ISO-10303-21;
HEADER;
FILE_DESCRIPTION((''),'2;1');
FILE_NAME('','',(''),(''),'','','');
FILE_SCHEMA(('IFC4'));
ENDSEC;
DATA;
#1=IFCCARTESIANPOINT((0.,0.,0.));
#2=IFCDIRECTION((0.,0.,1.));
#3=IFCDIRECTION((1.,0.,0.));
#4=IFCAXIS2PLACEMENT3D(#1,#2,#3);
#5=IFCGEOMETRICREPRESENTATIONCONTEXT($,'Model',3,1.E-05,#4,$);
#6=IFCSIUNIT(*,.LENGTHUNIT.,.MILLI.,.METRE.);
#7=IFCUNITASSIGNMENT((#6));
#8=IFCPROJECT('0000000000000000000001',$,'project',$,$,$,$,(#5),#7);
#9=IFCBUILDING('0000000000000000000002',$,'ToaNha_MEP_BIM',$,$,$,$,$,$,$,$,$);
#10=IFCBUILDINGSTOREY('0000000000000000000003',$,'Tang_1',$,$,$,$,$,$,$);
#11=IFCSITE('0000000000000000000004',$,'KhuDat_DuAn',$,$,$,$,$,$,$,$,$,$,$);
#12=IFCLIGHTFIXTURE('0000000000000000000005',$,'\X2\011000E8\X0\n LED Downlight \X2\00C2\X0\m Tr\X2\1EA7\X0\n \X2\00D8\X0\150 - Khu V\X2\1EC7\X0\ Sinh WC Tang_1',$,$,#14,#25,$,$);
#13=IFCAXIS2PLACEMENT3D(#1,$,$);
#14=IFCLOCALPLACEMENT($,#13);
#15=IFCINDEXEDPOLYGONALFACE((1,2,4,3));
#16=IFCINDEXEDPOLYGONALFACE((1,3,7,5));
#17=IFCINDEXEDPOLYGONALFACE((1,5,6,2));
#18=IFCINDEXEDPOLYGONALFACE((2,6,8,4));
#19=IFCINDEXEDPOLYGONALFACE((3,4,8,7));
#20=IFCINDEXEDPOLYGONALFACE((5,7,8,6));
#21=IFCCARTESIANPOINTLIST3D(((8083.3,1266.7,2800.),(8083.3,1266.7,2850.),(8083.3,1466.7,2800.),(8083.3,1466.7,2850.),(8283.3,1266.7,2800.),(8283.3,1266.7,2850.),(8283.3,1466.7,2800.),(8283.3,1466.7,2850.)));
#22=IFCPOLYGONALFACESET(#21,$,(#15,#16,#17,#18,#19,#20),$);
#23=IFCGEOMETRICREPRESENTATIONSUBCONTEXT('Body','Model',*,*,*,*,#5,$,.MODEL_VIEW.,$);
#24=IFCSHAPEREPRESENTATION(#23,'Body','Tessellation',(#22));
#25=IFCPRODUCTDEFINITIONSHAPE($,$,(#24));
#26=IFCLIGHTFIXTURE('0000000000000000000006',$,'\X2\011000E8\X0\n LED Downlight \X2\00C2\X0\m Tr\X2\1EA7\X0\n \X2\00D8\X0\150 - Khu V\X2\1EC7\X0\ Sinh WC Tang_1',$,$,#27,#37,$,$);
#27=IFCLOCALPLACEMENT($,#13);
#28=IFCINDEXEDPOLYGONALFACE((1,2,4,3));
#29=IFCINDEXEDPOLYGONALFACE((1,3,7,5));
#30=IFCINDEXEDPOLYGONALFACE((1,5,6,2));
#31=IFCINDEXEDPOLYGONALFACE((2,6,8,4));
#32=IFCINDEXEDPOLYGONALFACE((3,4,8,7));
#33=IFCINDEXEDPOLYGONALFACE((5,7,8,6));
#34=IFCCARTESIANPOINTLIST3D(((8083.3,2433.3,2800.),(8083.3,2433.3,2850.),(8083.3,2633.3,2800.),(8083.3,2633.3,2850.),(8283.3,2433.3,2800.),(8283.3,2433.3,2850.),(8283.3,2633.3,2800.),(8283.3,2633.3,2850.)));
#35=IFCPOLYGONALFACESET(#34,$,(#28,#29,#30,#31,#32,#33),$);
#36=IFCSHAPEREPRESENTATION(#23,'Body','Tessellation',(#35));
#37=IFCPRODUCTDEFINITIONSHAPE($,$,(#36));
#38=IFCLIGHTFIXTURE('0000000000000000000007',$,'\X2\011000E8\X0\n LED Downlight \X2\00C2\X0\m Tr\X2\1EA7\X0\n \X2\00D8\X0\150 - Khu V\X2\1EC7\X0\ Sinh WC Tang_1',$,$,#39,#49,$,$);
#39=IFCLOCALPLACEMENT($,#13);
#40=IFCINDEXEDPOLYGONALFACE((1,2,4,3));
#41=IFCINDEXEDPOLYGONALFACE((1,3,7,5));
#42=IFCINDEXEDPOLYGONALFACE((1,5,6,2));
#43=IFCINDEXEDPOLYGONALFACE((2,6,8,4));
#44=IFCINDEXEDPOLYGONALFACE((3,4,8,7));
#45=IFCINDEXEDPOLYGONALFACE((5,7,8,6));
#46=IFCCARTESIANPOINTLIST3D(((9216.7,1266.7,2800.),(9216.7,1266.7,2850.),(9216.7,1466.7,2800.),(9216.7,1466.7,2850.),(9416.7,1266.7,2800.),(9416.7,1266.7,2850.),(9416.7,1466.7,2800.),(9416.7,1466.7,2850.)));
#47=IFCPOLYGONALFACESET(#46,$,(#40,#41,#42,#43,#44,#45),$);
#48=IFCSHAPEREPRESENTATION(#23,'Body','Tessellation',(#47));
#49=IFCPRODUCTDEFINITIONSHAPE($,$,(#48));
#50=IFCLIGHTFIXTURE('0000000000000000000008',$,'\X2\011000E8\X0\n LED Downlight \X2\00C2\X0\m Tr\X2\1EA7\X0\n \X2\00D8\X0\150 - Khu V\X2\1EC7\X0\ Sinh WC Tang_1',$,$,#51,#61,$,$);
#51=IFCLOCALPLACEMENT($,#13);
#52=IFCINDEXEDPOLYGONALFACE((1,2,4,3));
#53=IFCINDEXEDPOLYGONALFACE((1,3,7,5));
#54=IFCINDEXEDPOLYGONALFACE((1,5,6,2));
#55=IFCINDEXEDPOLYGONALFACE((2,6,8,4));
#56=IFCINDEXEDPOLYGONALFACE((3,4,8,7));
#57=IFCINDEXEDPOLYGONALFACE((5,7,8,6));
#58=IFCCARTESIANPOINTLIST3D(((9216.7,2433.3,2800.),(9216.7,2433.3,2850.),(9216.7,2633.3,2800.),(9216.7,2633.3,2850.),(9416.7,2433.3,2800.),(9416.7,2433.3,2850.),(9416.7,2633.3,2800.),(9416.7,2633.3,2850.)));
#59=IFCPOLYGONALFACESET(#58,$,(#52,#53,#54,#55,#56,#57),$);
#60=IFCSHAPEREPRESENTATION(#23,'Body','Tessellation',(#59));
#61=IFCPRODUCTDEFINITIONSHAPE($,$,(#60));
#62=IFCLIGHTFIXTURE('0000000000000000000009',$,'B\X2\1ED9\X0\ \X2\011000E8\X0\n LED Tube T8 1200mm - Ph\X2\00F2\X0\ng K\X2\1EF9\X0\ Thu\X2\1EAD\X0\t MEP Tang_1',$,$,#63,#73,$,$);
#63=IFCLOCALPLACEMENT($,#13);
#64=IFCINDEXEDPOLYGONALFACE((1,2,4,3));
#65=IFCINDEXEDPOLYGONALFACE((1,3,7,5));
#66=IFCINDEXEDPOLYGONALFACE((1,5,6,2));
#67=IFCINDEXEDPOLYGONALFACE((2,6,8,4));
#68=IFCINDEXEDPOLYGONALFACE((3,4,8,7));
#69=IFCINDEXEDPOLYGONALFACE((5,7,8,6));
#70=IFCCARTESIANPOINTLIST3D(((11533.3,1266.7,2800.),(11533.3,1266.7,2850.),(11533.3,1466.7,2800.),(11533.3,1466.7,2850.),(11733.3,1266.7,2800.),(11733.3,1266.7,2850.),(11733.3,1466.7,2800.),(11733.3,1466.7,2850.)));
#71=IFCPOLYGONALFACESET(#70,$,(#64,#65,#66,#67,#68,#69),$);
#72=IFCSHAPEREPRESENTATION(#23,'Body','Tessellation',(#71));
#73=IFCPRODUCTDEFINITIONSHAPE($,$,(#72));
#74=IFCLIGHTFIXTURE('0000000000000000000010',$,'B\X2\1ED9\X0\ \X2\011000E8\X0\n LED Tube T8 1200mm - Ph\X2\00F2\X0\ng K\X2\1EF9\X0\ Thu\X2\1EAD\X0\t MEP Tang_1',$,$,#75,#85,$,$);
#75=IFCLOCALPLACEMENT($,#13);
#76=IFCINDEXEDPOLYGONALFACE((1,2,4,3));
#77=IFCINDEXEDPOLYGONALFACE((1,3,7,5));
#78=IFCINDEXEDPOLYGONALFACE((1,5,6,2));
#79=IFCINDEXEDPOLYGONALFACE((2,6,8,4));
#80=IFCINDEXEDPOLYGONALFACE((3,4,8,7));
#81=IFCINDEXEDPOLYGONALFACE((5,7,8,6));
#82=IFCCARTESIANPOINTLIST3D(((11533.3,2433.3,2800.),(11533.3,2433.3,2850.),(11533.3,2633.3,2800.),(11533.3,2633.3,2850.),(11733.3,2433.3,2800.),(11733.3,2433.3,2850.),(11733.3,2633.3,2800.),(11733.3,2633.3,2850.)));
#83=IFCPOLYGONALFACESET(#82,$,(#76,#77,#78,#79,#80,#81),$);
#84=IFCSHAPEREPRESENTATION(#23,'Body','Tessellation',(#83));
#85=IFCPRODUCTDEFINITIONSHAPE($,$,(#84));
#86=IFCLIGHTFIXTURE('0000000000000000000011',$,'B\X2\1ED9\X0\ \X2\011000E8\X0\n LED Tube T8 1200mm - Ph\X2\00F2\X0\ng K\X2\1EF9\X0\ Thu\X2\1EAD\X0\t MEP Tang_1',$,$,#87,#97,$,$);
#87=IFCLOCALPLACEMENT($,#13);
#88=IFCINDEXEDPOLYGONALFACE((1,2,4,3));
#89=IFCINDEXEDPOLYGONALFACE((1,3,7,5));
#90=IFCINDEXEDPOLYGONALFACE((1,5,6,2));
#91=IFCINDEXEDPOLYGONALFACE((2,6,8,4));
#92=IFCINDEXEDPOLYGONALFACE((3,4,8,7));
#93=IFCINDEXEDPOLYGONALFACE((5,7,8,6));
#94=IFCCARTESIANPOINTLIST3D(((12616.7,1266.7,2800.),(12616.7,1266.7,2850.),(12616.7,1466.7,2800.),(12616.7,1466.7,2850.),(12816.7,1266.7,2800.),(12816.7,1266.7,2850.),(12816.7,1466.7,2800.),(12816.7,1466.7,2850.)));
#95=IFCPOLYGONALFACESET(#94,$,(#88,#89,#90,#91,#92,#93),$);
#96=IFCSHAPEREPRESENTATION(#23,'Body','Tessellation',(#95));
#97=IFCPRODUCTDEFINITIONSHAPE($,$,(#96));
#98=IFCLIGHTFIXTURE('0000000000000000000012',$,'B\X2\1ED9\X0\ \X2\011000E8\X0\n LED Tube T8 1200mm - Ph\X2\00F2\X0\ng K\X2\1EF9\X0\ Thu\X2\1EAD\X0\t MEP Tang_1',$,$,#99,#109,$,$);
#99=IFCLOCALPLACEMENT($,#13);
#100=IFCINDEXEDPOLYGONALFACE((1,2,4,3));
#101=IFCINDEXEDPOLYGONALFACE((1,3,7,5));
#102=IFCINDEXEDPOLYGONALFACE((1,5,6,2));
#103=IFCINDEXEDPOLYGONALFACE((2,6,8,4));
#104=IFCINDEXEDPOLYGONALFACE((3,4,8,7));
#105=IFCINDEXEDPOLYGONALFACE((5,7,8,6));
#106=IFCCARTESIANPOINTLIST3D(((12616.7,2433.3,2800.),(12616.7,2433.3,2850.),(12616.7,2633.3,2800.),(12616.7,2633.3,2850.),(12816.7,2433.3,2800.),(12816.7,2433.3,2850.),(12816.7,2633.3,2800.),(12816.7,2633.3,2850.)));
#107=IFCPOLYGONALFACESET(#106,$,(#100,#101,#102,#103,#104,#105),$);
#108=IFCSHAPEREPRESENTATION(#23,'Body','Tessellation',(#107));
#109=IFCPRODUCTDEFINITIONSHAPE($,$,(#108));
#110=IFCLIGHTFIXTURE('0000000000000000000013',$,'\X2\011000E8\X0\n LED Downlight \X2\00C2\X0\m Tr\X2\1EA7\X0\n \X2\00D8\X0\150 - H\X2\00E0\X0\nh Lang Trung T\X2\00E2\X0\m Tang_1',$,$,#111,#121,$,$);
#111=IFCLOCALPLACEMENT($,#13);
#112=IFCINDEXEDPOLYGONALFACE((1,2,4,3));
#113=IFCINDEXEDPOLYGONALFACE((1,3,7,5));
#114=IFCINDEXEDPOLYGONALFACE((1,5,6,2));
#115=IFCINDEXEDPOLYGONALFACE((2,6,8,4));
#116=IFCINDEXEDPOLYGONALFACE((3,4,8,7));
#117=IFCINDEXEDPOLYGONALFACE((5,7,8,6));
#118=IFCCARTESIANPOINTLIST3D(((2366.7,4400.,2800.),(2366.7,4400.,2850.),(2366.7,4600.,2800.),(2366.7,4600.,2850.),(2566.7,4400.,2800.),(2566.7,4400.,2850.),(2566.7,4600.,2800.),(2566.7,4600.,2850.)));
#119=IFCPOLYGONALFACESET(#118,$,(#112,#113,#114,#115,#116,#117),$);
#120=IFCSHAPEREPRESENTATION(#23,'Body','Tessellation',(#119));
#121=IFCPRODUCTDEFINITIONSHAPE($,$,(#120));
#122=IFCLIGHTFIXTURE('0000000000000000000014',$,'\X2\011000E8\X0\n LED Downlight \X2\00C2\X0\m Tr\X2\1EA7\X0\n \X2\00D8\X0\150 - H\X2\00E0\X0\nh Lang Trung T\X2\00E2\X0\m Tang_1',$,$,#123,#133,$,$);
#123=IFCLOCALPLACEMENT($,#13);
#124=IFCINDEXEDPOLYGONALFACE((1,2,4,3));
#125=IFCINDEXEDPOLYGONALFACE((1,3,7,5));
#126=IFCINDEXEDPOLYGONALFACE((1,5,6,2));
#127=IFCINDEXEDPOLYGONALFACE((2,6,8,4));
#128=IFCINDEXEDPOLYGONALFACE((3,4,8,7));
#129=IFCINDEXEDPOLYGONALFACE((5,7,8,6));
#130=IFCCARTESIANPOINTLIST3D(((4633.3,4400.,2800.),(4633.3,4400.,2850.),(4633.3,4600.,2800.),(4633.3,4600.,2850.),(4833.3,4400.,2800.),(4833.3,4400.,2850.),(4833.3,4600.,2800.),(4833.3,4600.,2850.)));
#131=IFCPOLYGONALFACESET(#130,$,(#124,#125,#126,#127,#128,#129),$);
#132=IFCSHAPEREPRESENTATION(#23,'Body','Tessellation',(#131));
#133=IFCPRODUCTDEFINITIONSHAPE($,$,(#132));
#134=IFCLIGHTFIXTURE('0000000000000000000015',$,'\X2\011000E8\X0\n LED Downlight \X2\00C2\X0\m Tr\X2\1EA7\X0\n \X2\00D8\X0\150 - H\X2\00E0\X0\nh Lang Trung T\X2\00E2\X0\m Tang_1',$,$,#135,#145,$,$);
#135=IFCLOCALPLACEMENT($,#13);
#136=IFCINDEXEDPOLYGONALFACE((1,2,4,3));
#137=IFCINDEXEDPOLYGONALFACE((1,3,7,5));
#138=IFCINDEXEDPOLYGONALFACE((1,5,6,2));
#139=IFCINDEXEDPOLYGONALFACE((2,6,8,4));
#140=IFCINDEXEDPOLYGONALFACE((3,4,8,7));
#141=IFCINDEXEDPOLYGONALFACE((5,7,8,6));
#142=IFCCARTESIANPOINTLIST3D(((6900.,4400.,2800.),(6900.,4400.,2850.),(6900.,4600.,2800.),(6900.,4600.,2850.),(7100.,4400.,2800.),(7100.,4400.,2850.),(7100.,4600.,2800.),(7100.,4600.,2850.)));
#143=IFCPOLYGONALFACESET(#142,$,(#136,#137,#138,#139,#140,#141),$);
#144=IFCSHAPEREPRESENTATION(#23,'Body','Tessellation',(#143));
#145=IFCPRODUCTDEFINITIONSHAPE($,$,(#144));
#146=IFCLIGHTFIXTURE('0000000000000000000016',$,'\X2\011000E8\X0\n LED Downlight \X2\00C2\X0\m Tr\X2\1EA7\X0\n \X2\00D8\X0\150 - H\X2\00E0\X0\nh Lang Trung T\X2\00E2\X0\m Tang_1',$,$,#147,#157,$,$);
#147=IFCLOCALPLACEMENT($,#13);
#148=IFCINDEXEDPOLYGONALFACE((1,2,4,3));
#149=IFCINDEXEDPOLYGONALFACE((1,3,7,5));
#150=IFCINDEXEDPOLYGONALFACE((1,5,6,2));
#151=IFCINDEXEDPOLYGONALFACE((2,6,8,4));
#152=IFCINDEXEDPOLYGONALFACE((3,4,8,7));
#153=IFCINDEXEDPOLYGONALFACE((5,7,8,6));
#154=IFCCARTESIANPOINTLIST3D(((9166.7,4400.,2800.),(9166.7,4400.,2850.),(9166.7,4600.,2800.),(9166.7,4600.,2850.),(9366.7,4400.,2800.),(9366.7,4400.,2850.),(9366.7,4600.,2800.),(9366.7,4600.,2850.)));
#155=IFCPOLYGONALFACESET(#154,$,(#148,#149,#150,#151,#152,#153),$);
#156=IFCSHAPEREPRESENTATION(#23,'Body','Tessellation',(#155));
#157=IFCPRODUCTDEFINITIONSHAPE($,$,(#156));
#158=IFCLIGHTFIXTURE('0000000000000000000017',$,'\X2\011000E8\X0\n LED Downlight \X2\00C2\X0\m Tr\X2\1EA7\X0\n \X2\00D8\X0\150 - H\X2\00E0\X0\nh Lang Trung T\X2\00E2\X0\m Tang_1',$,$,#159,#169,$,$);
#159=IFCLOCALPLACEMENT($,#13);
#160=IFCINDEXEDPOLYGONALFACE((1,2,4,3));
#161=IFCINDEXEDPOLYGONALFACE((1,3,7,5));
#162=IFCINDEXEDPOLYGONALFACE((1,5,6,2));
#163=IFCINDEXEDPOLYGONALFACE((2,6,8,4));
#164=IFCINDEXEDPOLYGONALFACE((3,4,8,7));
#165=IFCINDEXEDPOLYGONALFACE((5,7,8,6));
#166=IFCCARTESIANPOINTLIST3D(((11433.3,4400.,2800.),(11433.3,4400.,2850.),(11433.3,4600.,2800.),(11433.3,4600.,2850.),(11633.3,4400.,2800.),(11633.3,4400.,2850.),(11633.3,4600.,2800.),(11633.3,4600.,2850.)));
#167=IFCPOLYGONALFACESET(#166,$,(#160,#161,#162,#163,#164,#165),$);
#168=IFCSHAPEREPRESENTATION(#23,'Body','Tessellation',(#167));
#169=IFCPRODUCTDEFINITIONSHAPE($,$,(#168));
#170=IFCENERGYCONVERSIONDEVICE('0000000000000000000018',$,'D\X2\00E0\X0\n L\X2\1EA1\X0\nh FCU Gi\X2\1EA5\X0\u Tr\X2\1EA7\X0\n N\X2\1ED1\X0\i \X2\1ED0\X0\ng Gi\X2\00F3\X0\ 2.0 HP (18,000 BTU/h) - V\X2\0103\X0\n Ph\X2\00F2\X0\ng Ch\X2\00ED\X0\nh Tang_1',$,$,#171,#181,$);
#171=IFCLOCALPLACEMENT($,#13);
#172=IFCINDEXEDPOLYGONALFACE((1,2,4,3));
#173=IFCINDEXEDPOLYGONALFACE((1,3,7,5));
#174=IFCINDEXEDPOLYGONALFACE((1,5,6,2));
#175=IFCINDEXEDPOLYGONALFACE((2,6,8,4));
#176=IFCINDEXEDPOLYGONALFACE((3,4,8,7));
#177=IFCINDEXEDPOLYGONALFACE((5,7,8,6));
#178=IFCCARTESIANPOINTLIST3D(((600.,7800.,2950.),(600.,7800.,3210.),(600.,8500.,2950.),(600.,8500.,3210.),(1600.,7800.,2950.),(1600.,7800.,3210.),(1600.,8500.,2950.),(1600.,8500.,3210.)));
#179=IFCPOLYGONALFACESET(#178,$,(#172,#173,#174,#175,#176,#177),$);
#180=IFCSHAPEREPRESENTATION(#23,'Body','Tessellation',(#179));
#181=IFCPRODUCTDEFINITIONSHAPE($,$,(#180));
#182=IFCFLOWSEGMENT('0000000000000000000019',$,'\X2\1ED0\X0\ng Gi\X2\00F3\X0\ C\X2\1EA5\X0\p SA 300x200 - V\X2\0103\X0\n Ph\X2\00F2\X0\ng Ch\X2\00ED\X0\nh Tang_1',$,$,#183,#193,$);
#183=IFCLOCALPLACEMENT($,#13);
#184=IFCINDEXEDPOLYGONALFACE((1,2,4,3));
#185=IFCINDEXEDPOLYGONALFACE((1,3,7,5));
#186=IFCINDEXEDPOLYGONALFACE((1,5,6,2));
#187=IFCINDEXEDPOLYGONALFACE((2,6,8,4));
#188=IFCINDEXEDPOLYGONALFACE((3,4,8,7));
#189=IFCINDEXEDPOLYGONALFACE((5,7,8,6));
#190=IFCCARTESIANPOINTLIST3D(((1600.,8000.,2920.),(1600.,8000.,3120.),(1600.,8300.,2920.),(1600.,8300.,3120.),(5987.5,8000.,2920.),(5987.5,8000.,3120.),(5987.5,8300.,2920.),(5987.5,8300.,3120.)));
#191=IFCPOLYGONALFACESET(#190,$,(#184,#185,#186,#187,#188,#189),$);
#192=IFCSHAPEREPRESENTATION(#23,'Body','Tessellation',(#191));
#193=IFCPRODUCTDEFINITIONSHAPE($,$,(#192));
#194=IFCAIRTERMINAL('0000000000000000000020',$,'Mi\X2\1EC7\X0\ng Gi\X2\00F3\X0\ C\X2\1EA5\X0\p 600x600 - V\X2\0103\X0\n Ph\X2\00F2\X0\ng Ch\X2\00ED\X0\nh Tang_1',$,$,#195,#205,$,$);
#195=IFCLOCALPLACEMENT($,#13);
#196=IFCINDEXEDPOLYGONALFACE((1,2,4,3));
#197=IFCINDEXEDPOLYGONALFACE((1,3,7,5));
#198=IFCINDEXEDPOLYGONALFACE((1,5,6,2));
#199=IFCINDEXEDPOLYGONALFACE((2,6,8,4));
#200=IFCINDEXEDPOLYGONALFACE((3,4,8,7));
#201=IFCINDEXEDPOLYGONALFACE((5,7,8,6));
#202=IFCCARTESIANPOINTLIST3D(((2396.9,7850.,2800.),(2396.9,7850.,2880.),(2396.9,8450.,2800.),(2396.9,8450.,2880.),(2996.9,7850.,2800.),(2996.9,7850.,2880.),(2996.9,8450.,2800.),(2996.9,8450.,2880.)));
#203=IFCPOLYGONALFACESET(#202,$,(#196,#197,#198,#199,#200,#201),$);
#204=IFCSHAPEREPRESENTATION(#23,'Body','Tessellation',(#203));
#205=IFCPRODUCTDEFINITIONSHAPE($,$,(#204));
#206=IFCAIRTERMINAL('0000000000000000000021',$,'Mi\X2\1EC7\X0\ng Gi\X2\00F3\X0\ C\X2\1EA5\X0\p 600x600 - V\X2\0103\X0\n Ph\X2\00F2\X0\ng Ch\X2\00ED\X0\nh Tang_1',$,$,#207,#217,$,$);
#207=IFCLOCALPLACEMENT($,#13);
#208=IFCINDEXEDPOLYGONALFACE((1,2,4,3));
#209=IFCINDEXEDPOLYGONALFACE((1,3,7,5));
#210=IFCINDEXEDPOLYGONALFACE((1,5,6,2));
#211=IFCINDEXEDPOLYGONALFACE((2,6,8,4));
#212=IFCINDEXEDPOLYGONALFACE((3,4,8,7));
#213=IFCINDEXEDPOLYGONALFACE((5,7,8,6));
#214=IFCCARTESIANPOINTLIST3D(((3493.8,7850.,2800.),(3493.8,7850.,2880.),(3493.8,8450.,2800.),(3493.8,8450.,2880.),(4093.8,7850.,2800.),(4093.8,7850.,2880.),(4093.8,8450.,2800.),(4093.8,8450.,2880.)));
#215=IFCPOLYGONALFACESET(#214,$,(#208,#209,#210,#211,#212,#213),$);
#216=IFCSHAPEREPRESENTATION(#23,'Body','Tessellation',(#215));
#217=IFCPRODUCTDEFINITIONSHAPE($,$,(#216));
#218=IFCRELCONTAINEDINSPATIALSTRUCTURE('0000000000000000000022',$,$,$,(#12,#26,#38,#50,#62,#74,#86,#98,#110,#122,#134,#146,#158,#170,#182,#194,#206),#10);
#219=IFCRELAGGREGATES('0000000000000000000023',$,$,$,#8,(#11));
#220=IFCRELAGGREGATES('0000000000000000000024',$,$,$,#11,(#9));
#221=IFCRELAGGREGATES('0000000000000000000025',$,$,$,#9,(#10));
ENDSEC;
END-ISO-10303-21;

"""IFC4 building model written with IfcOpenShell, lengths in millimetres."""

from ifc_helpers import new_model, si_unit, frame, origin_with_axes, context, subcontext, project, spatial, polyline, outline, extrude, element, save


model = new_model("IFC4")

# Units and contexts
model_context = context("Model", 3, precision=1e-05, world=origin_with_axes())
body_context = subcontext(model_context, "Body", "Model", "MODEL_VIEW")
ifc_project = project(units=[si_unit("LENGTHUNIT", "METRE", prefix="MILLI")], contexts=[model_context])

# Site, building, storey
site = spatial("IfcSite", under=ifc_project, Name="KhuDat_DuAn")
building = spatial("IfcBuilding", under=site, Name="ToaNha_MEP_BIM")
storey = spatial("IfcBuildingStorey", under=building, Name="Tang_1")

# Light fixtures
element("IfcLightFixture", 1, inside=storey, Name="Đèn LED Downlight Âm Trần Ø150 - Khu Vệ Sinh WC Tang_1", context=body_context, shape_type="SweptSolid", body=[
    extrude(outline(polyline([(8083.3, 1266.7), (8283.3, 1266.7), (8283.3, 1466.7), (8083.3, 1466.7), (8083.3, 1266.7)])), frame((0.0, 0.0, 2800.0), z_axis=(0.0, 0.0, 1.0), x_axis=(1.0, 0.0, 0.0)), (0.0, 0.0, 1.0), 50.0),
])
element("IfcLightFixture", 2, inside=storey, Name="Đèn LED Downlight Âm Trần Ø150 - Khu Vệ Sinh WC Tang_1", context=body_context, shape_type="SweptSolid", body=[
    extrude(outline(polyline([(8083.3, 2433.3), (8283.3, 2433.3), (8283.3, 2633.3), (8083.3, 2633.3), (8083.3, 2433.3)])), frame((0.0, 0.0, 2800.0), z_axis=(0.0, 0.0, 1.0), x_axis=(1.0, 0.0, 0.0)), (0.0, 0.0, 1.0), 50.0),
])
element("IfcLightFixture", 3, inside=storey, Name="Đèn LED Downlight Âm Trần Ø150 - Khu Vệ Sinh WC Tang_1", context=body_context, shape_type="SweptSolid", body=[
    extrude(outline(polyline([(9216.7, 1266.7), (9416.7, 1266.7), (9416.7, 1466.7), (9216.7, 1466.7), (9216.7, 1266.7)])), frame((0.0, 0.0, 2800.0), z_axis=(0.0, 0.0, 1.0), x_axis=(1.0, 0.0, 0.0)), (0.0, 0.0, 1.0), 50.0),
])
element("IfcLightFixture", 4, inside=storey, Name="Đèn LED Downlight Âm Trần Ø150 - Khu Vệ Sinh WC Tang_1", context=body_context, shape_type="SweptSolid", body=[
    extrude(outline(polyline([(9216.7, 2433.3), (9416.7, 2433.3), (9416.7, 2633.3), (9216.7, 2633.3), (9216.7, 2433.3)])), frame((0.0, 0.0, 2800.0), z_axis=(0.0, 0.0, 1.0), x_axis=(1.0, 0.0, 0.0)), (0.0, 0.0, 1.0), 50.0),
])
element("IfcLightFixture", 5, inside=storey, Name="Bộ Đèn LED Tube T8 1200mm - Phòng Kỹ Thuật MEP Tang_1", context=body_context, shape_type="SweptSolid", body=[
    extrude(outline(polyline([(11533.3, 1266.7), (11733.3, 1266.7), (11733.3, 1466.7), (11533.3, 1466.7), (11533.3, 1266.7)])), frame((0.0, 0.0, 2800.0), z_axis=(0.0, 0.0, 1.0), x_axis=(1.0, 0.0, 0.0)), (0.0, 0.0, 1.0), 50.0),
])
element("IfcLightFixture", 6, inside=storey, Name="Bộ Đèn LED Tube T8 1200mm - Phòng Kỹ Thuật MEP Tang_1", context=body_context, shape_type="SweptSolid", body=[
    extrude(outline(polyline([(11533.3, 2433.3), (11733.3, 2433.3), (11733.3, 2633.3), (11533.3, 2633.3), (11533.3, 2433.3)])), frame((0.0, 0.0, 2800.0), z_axis=(0.0, 0.0, 1.0), x_axis=(1.0, 0.0, 0.0)), (0.0, 0.0, 1.0), 50.0),
])
element("IfcLightFixture", 7, inside=storey, Name="Bộ Đèn LED Tube T8 1200mm - Phòng Kỹ Thuật MEP Tang_1", context=body_context, shape_type="SweptSolid", body=[
    extrude(outline(polyline([(12616.7, 1266.7), (12816.7, 1266.7), (12816.7, 1466.7), (12616.7, 1466.7), (12616.7, 1266.7)])), frame((0.0, 0.0, 2800.0), z_axis=(0.0, 0.0, 1.0), x_axis=(1.0, 0.0, 0.0)), (0.0, 0.0, 1.0), 50.0),
])
element("IfcLightFixture", 8, inside=storey, Name="Bộ Đèn LED Tube T8 1200mm - Phòng Kỹ Thuật MEP Tang_1", context=body_context, shape_type="SweptSolid", body=[
    extrude(outline(polyline([(12616.7, 2433.3), (12816.7, 2433.3), (12816.7, 2633.3), (12616.7, 2633.3), (12616.7, 2433.3)])), frame((0.0, 0.0, 2800.0), z_axis=(0.0, 0.0, 1.0), x_axis=(1.0, 0.0, 0.0)), (0.0, 0.0, 1.0), 50.0),
])
element("IfcLightFixture", 9, inside=storey, Name="Đèn LED Downlight Âm Trần Ø150 - Hành Lang Trung Tâm Tang_1", context=body_context, shape_type="SweptSolid", body=[
    extrude(outline(polyline([(2366.7, 4400.0), (2566.7, 4400.0), (2566.7, 4600.0), (2366.7, 4600.0), (2366.7, 4400.0)])), frame((0.0, 0.0, 2800.0), z_axis=(0.0, 0.0, 1.0), x_axis=(1.0, 0.0, 0.0)), (0.0, 0.0, 1.0), 50.0),
])
element("IfcLightFixture", 10, inside=storey, Name="Đèn LED Downlight Âm Trần Ø150 - Hành Lang Trung Tâm Tang_1", context=body_context, shape_type="SweptSolid", body=[
    extrude(outline(polyline([(4633.3, 4400.0), (4833.3, 4400.0), (4833.3, 4600.0), (4633.3, 4600.0), (4633.3, 4400.0)])), frame((0.0, 0.0, 2800.0), z_axis=(0.0, 0.0, 1.0), x_axis=(1.0, 0.0, 0.0)), (0.0, 0.0, 1.0), 50.0),
])
element("IfcLightFixture", 11, inside=storey, Name="Đèn LED Downlight Âm Trần Ø150 - Hành Lang Trung Tâm Tang_1", context=body_context, shape_type="SweptSolid", body=[
    extrude(outline(polyline([(6900.0, 4400.0), (7100.0, 4400.0), (7100.0, 4600.0), (6900.0, 4600.0), (6900.0, 4400.0)])), frame((0.0, 0.0, 2800.0), z_axis=(0.0, 0.0, 1.0), x_axis=(1.0, 0.0, 0.0)), (0.0, 0.0, 1.0), 50.0),
])
element("IfcLightFixture", 12, inside=storey, Name="Đèn LED Downlight Âm Trần Ø150 - Hành Lang Trung Tâm Tang_1", context=body_context, shape_type="SweptSolid", body=[
    extrude(outline(polyline([(9166.7, 4400.0), (9366.7, 4400.0), (9366.7, 4600.0), (9166.7, 4600.0), (9166.7, 4400.0)])), frame((0.0, 0.0, 2800.0), z_axis=(0.0, 0.0, 1.0), x_axis=(1.0, 0.0, 0.0)), (0.0, 0.0, 1.0), 50.0),
])
element("IfcLightFixture", 13, inside=storey, Name="Đèn LED Downlight Âm Trần Ø150 - Hành Lang Trung Tâm Tang_1", context=body_context, shape_type="SweptSolid", body=[
    extrude(outline(polyline([(11433.3, 4400.0), (11633.3, 4400.0), (11633.3, 4600.0), (11433.3, 4600.0), (11433.3, 4400.0)])), frame((0.0, 0.0, 2800.0), z_axis=(0.0, 0.0, 1.0), x_axis=(1.0, 0.0, 0.0)), (0.0, 0.0, 1.0), 50.0),
])

# Energy conversion device
element("IfcEnergyConversionDevice", 14, inside=storey, Name="Dàn Lạnh FCU Giấu Trần Nối Ống Gió 2.0 HP (18,000 BTU/h) - Văn Phòng Chính Tang_1", context=body_context, shape_type="SweptSolid", body=[
    extrude(outline(polyline([(600.0, 7800.0), (1600.0, 7800.0), (1600.0, 8500.0), (600.0, 8500.0), (600.0, 7800.0)])), frame((0.0, 0.0, 2950.0), z_axis=(0.0, 0.0, 1.0), x_axis=(1.0, 0.0, 0.0)), (0.0, 0.0, 1.0), 260.0),
])

# Flow segment
element("IfcFlowSegment", 15, inside=storey, Name="Ống Gió Cấp SA 300x200 - Văn Phòng Chính Tang_1", context=body_context, shape_type="SweptSolid", body=[
    extrude(outline(polyline([(1600.0, 8000.0), (5987.5, 8000.0), (5987.5, 8300.0), (1600.0, 8300.0), (1600.0, 8000.0)])), frame((0.0, 0.0, 2920.0), z_axis=(0.0, 0.0, 1.0), x_axis=(1.0, 0.0, 0.0)), (0.0, 0.0, 1.0), 200.0),
])

# Air terminals
element("IfcAirTerminal", 16, inside=storey, Name="Miệng Gió Cấp 600x600 - Văn Phòng Chính Tang_1", context=body_context, shape_type="SweptSolid", body=[
    extrude(outline(polyline([(2396.9, 7850.0), (2996.9, 7850.0), (2996.9, 8450.0), (2396.9, 8450.0), (2396.9, 7850.0)])), frame((0.0, 0.0, 2800.0), z_axis=(0.0, 0.0, 1.0), x_axis=(1.0, 0.0, 0.0)), (0.0, 0.0, 1.0), 80.0),
])
element("IfcAirTerminal", 17, inside=storey, Name="Miệng Gió Cấp 600x600 - Văn Phòng Chính Tang_1", context=body_context, shape_type="SweptSolid", body=[
    extrude(outline(polyline([(3493.8, 7850.0), (4093.8, 7850.0), (4093.8, 8450.0), (3493.8, 8450.0), (3493.8, 7850.0)])), frame((0.0, 0.0, 2800.0), z_axis=(0.0, 0.0, 1.0), x_axis=(1.0, 0.0, 0.0)), (0.0, 0.0, 1.0), 80.0),
])

save(model, "model.ifc")
